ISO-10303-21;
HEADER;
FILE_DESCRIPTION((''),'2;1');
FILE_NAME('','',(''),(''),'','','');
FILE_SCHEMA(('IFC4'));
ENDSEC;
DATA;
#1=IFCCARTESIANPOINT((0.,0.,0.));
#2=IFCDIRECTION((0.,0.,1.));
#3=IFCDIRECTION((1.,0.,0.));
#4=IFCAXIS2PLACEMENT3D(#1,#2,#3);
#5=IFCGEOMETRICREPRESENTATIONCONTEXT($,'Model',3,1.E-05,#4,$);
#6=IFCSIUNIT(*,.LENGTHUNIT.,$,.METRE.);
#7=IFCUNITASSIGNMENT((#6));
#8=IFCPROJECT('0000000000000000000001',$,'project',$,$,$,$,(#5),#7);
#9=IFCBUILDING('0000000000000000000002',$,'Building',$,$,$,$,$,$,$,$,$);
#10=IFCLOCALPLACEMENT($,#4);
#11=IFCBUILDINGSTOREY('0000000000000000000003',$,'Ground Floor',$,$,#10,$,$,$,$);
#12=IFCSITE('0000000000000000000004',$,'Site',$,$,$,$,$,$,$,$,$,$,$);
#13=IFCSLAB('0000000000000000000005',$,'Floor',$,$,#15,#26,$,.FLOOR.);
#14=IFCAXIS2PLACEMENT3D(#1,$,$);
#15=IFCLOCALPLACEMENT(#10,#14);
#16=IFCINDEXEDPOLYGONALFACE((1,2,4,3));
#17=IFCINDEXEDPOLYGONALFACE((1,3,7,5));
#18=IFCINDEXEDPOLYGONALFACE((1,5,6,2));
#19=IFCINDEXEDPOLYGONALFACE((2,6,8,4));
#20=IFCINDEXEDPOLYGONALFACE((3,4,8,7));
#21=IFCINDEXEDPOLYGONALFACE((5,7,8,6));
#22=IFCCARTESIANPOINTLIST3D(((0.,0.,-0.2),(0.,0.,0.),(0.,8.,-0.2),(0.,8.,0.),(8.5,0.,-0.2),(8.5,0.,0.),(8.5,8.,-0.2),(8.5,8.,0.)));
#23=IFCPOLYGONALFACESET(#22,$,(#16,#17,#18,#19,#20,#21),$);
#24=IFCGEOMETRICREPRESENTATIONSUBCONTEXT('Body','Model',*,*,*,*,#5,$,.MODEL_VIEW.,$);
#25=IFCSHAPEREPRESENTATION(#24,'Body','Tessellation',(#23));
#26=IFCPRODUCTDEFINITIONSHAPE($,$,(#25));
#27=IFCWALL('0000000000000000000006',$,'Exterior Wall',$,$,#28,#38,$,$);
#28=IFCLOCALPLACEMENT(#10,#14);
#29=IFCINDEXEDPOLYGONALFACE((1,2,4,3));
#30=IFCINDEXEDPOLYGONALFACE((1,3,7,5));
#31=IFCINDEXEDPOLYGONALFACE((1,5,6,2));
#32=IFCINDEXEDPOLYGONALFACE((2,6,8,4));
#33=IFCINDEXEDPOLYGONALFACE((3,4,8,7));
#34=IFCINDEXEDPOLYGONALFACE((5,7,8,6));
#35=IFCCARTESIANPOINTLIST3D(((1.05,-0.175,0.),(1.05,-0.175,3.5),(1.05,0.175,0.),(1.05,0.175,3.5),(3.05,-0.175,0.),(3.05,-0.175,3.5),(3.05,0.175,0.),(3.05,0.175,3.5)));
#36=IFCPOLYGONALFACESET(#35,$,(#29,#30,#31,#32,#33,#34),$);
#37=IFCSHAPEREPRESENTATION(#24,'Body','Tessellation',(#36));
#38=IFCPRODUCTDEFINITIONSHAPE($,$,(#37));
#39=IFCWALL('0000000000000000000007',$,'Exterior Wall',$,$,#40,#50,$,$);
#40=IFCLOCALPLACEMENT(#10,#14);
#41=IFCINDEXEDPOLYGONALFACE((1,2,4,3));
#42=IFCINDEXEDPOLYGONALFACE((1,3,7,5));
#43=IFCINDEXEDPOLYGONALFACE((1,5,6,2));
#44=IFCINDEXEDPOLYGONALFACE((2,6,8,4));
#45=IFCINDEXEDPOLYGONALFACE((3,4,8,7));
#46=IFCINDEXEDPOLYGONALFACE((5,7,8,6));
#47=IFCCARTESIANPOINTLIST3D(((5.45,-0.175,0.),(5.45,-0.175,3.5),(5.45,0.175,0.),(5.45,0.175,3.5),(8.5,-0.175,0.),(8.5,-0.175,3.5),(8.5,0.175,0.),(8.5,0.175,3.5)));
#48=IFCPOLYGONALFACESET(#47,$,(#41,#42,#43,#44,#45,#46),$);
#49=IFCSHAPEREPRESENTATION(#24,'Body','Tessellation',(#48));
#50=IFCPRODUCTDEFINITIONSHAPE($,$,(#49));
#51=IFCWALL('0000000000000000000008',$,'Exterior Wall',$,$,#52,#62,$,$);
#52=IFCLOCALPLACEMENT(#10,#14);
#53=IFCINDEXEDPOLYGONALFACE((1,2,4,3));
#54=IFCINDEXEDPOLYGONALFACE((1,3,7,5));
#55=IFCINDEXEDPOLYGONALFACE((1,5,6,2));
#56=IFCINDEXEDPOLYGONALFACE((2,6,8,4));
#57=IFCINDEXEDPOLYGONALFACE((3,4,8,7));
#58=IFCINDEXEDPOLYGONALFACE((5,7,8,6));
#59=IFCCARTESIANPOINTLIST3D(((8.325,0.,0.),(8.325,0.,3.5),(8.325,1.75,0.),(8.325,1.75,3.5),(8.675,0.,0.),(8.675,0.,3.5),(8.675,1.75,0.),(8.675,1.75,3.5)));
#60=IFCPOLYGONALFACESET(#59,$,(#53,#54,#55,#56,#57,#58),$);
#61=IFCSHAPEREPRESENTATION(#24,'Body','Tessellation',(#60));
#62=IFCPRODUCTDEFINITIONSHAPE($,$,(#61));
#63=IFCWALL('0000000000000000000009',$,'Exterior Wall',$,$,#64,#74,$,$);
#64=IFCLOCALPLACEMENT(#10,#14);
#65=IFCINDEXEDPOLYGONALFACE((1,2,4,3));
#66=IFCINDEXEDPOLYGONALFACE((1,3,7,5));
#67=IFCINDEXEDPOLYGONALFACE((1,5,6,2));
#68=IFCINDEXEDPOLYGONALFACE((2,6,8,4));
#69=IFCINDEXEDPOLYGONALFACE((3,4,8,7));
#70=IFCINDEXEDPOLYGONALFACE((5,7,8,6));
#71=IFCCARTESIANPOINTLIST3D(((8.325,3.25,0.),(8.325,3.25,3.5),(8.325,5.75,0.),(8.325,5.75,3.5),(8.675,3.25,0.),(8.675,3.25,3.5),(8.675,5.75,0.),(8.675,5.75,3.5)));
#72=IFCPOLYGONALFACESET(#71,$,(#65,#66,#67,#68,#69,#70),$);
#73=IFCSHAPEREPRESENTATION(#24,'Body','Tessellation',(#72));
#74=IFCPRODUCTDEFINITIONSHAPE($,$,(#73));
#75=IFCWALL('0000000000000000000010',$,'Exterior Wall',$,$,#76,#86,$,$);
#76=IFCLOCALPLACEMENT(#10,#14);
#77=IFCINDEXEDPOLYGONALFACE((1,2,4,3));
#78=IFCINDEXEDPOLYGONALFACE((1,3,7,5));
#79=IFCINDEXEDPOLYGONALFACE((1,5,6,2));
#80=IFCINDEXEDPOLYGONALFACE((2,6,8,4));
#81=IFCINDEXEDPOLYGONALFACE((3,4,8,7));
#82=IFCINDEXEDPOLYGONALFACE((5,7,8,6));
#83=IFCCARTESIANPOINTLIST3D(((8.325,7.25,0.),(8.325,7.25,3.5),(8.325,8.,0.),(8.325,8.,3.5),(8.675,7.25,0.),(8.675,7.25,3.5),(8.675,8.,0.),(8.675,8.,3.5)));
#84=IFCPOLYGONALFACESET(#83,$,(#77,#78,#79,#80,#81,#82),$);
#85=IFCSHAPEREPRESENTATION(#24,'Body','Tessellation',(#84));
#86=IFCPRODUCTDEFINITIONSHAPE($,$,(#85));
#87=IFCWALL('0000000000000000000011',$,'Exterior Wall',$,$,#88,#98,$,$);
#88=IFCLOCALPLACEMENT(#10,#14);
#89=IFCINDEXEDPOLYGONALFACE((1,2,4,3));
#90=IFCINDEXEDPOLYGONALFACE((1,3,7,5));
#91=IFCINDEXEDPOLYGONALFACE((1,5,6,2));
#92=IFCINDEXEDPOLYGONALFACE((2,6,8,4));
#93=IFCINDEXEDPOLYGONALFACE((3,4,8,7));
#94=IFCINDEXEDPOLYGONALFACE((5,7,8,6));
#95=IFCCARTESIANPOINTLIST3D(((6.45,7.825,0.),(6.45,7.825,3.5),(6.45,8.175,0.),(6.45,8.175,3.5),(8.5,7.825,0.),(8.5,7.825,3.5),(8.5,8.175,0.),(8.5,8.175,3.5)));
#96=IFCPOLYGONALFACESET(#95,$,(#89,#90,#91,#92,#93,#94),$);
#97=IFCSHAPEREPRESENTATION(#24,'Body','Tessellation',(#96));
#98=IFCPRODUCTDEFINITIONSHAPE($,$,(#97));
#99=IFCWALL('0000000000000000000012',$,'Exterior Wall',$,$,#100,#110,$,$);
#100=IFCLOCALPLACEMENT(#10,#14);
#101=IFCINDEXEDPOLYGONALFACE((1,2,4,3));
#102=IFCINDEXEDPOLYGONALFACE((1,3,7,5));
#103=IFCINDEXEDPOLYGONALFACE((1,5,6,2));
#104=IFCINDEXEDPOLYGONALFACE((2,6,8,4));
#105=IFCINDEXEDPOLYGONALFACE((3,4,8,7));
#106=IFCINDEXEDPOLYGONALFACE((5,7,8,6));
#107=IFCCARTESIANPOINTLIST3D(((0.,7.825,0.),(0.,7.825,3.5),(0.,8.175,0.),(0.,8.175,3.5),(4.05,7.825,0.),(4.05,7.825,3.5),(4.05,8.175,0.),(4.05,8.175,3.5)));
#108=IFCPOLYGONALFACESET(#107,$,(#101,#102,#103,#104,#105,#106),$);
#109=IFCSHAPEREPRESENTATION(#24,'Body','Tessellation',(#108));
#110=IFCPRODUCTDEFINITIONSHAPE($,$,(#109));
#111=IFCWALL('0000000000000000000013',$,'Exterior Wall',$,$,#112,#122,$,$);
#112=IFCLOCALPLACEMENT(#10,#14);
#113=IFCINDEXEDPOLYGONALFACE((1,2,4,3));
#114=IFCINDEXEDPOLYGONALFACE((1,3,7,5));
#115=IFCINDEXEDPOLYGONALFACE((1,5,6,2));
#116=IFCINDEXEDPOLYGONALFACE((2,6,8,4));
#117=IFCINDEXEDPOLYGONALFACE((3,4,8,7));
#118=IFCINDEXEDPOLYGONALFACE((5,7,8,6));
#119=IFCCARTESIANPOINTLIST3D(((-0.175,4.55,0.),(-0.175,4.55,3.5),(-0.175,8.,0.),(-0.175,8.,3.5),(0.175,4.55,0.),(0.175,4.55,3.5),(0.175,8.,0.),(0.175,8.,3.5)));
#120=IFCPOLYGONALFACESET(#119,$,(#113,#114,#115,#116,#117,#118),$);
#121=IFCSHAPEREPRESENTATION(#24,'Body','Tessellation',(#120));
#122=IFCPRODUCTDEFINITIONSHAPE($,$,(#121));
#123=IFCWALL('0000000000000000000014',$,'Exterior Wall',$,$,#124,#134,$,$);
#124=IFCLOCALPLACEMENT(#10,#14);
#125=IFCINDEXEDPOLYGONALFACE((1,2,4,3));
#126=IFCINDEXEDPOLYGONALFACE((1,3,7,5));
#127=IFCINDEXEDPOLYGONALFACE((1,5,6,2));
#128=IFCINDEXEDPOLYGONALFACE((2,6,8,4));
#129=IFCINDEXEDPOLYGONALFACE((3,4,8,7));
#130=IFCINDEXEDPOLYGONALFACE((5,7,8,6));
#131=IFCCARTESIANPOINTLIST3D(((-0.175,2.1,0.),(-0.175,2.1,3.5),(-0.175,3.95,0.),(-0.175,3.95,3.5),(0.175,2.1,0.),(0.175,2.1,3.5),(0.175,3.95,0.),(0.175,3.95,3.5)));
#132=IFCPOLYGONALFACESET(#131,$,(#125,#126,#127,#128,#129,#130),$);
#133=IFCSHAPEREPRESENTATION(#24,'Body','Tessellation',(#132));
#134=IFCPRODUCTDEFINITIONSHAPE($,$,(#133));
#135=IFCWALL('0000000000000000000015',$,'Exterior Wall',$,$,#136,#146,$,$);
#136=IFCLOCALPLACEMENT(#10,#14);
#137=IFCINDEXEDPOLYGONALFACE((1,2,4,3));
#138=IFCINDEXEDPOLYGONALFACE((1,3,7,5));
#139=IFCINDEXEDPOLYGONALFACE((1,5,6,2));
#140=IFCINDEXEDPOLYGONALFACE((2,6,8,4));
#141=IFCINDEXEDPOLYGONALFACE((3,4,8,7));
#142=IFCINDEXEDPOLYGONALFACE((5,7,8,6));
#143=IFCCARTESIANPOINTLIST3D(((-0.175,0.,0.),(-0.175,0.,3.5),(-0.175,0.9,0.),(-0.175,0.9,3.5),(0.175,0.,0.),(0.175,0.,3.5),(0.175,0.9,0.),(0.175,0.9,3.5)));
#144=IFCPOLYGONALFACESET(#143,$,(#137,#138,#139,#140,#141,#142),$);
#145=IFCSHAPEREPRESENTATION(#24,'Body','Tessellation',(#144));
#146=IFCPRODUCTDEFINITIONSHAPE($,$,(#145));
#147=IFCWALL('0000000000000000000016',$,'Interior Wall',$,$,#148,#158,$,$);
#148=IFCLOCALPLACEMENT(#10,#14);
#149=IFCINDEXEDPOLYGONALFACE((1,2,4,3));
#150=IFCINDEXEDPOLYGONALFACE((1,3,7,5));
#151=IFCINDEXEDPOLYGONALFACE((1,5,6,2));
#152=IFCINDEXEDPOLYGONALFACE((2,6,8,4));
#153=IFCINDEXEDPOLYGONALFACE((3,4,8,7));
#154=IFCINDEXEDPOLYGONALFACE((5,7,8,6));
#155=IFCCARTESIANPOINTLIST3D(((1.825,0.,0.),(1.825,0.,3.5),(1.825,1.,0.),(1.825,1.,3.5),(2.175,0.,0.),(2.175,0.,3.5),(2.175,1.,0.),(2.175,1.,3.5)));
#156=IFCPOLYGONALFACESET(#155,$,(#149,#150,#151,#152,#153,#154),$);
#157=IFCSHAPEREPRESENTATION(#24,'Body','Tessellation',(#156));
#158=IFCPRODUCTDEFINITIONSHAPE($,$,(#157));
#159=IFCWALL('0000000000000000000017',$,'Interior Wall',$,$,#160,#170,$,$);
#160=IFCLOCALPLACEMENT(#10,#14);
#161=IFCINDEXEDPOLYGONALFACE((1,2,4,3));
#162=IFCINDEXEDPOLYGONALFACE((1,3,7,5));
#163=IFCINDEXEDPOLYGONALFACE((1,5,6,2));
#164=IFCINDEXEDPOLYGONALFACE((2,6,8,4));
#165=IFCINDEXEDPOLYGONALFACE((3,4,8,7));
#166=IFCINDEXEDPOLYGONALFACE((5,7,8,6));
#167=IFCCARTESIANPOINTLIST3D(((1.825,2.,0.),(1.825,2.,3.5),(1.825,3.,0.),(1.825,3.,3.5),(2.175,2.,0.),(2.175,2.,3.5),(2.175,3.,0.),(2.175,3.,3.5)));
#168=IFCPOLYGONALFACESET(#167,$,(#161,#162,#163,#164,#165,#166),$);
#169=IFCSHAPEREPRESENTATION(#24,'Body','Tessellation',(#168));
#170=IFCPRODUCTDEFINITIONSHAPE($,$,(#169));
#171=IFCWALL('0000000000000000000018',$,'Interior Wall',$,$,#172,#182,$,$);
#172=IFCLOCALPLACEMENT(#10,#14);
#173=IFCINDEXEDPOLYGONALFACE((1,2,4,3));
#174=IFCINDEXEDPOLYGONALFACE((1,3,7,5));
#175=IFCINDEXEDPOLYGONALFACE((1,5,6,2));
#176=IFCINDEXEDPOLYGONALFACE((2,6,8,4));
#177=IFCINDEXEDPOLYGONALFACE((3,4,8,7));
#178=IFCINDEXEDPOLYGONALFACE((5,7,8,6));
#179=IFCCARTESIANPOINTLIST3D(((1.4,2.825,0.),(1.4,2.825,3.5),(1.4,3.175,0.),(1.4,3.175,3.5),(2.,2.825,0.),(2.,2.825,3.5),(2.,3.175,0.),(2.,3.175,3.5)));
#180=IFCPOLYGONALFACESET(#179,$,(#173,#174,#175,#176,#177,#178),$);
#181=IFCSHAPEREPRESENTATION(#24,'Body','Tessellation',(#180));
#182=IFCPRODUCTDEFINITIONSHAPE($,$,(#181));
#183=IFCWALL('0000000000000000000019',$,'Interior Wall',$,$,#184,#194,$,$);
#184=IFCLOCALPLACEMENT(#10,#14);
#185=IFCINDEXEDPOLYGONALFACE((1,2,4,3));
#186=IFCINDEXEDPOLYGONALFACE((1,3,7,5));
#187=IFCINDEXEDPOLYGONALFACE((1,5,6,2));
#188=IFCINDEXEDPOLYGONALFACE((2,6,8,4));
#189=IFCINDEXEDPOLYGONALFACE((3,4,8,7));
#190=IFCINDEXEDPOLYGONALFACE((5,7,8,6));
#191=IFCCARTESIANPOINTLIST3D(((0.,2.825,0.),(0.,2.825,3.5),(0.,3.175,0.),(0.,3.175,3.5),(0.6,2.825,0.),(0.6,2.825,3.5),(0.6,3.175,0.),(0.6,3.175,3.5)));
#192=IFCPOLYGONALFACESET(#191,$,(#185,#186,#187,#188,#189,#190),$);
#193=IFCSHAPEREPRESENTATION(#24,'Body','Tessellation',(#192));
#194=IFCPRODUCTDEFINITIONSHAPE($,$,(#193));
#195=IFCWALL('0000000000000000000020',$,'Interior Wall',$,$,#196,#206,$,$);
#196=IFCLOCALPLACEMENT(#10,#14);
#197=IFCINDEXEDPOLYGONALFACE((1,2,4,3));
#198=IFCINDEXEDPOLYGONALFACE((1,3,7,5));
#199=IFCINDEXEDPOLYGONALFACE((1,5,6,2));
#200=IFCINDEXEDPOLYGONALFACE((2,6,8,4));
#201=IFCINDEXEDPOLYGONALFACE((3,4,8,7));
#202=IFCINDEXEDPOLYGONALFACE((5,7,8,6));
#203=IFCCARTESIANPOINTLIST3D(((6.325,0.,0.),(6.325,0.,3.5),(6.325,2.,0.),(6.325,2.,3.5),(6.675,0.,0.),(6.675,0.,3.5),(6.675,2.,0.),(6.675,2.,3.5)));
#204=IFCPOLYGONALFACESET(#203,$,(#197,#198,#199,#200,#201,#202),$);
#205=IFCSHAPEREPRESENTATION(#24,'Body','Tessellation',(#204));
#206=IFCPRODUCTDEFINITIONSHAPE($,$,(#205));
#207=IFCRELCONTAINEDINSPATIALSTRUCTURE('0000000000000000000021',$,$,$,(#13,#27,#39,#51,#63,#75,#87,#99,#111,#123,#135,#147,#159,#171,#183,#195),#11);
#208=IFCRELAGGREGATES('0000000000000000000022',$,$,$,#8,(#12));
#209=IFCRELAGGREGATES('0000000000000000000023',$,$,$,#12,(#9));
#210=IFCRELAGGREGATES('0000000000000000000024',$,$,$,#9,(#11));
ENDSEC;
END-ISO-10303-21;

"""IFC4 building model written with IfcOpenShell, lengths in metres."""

from ifc_helpers import new_model, si_unit, frame, origin_with_axes, place, context, subcontext, project, spatial, indexed_curve, outline, extrude, element, save


model = new_model("IFC4")

# Units and contexts
model_context = context("Model", 3, precision=1e-05, world=origin_with_axes())
body_context = subcontext(model_context, "Body", "Model", "MODEL_VIEW")
ifc_project = project(units=[si_unit("LENGTHUNIT", "METRE")], contexts=[model_context])

# Site, building, storey
site = spatial("IfcSite", under=ifc_project, Name="Site")
building = spatial("IfcBuilding", under=site, Name="Building")
storey_placement = place(None, origin_with_axes())
storey = spatial("IfcBuildingStorey", under=building, at=storey_placement, Name="Ground Floor")

# Slab
slab_placement = place(storey_placement, frame((0.0, 0.0, -0.2), z_axis=(0.0, 0.0, 1.0), x_axis=(1.0, 0.0, 0.0)))
element("IfcSlab", 1, at=slab_placement, inside=storey, Name="Floor", PredefinedType="FLOOR", context=body_context, shape_type="SweptSolid", body=[
    extrude(outline(indexed_curve([(0.0, 0.0), (8.5, 0.0), (8.5, 8.0), (0.0, 8.0)])), None, (0.0, 0.0, 1.0), 0.2),
])

# Walls
wall_1_placement = place(storey_placement, frame((1.05, 0.0, 0.0), z_axis=(0.0, 0.0, 1.0), x_axis=(1.0, 0.0, 0.0)))
element("IfcWall", 2, at=wall_1_placement, inside=storey, Name="Exterior Wall", context=body_context, shape_type="SweptSolid", body=[
    extrude(outline(indexed_curve([(0.0, 0.0), (0.0, 0.35), (2.0, 0.35), (2.0, 0.0), (0.0, 0.0)], self_intersect=False)), frame((0.0, -0.175, 0.0), z_axis=(0.0, 0.0, 1.0), x_axis=(1.0, 0.0, 0.0)), (0.0, 0.0, 1.0), 3.5),
])
wall_2_placement = place(storey_placement, frame((5.45, 0.0, 0.0), z_axis=(0.0, 0.0, 1.0), x_axis=(1.0, 0.0, 0.0)))
element("IfcWall", 3, at=wall_2_placement, inside=storey, Name="Exterior Wall", context=body_context, shape_type="SweptSolid", body=[
    extrude(outline(indexed_curve([(0.0, 0.0), (0.0, 0.35), (3.05, 0.35), (3.05, 0.0), (0.0, 0.0)], self_intersect=False)), frame((0.0, -0.175, 0.0), z_axis=(0.0, 0.0, 1.0), x_axis=(1.0, 0.0, 0.0)), (0.0, 0.0, 1.0), 3.5),
])
wall_3_placement = place(storey_placement, frame((8.5, 0.0, 0.0), z_axis=(0.0, 0.0, 1.0), x_axis=(0.0, 1.0, 0.0)))
element("IfcWall", 4, at=wall_3_placement, inside=storey, Name="Exterior Wall", context=body_context, shape_type="SweptSolid", body=[
    extrude(outline(indexed_curve([(0.0, 0.0), (0.0, 0.35), (1.75, 0.35), (1.75, 0.0), (0.0, 0.0)], self_intersect=False)), frame((0.0, -0.175, 0.0), z_axis=(0.0, 0.0, 1.0), x_axis=(1.0, 0.0, 0.0)), (0.0, 0.0, 1.0), 3.5),
])
wall_4_placement = place(storey_placement, frame((8.5, 3.25, 0.0), z_axis=(0.0, 0.0, 1.0), x_axis=(0.0, 1.0, 0.0)))
element("IfcWall", 5, at=wall_4_placement, inside=storey, Name="Exterior Wall", context=body_context, shape_type="SweptSolid", body=[
    extrude(outline(indexed_curve([(0.0, 0.0), (0.0, 0.35), (2.5, 0.35), (2.5, 0.0), (0.0, 0.0)], self_intersect=False)), frame((0.0, -0.175, 0.0), z_axis=(0.0, 0.0, 1.0), x_axis=(1.0, 0.0, 0.0)), (0.0, 0.0, 1.0), 3.5),
])
wall_5_placement = place(storey_placement, frame((8.5, 7.25, 0.0), z_axis=(0.0, 0.0, 1.0), x_axis=(0.0, 1.0, 0.0)))
element("IfcWall", 6, at=wall_5_placement, inside=storey, Name="Exterior Wall", context=body_context, shape_type="SweptSolid", body=[
    extrude(outline(indexed_curve([(0.0, 0.0), (0.0, 0.35), (0.75, 0.35), (0.75, 0.0), (0.0, 0.0)], self_intersect=False)), frame((0.0, -0.175, 0.0), z_axis=(0.0, 0.0, 1.0), x_axis=(1.0, 0.0, 0.0)), (0.0, 0.0, 1.0), 3.5),
])
wall_6_placement = place(storey_placement, frame((8.5, 8.0, 0.0), z_axis=(0.0, 0.0, 1.0), x_axis=(-1.0, 0.0, 0.0)))
element("IfcWall", 7, at=wall_6_placement, inside=storey, Name="Exterior Wall", context=body_context, shape_type="SweptSolid", body=[
    extrude(outline(indexed_curve([(0.0, 0.0), (0.0, 0.35), (2.05, 0.35), (2.05, 0.0), (0.0, 0.0)], self_intersect=False)), frame((0.0, -0.175, 0.0), z_axis=(0.0, 0.0, 1.0), x_axis=(1.0, 0.0, 0.0)), (0.0, 0.0, 1.0), 3.5),
])
wall_7_placement = place(storey_placement, frame((4.05, 8.0, 0.0), z_axis=(0.0, 0.0, 1.0), x_axis=(-1.0, 0.0, 0.0)))
element("IfcWall", 8, at=wall_7_placement, inside=storey, Name="Exterior Wall", context=body_context, shape_type="SweptSolid", body=[
    extrude(outline(indexed_curve([(0.0, 0.0), (0.0, 0.35), (4.05, 0.35), (4.05, 0.0), (0.0, 0.0)], self_intersect=False)), frame((0.0, -0.175, 0.0), z_axis=(0.0, 0.0, 1.0), x_axis=(1.0, 0.0, 0.0)), (0.0, 0.0, 1.0), 3.5),
])
wall_8_placement = place(storey_placement, frame((0.0, 8.0, 0.0), z_axis=(0.0, 0.0, 1.0), x_axis=(0.0, -1.0, 0.0)))
element("IfcWall", 9, at=wall_8_placement, inside=storey, Name="Exterior Wall", context=body_context, shape_type="SweptSolid", body=[
    extrude(outline(indexed_curve([(0.0, 0.0), (0.0, 0.35), (3.45, 0.35), (3.45, 0.0), (0.0, 0.0)], self_intersect=False)), frame((0.0, -0.175, 0.0), z_axis=(0.0, 0.0, 1.0), x_axis=(1.0, 0.0, 0.0)), (0.0, 0.0, 1.0), 3.5),
])
wall_9_placement = place(storey_placement, frame((0.0, 3.95, 0.0), z_axis=(0.0, 0.0, 1.0), x_axis=(0.0, -1.0, 0.0)))
element("IfcWall", 10, at=wall_9_placement, inside=storey, Name="Exterior Wall", context=body_context, shape_type="SweptSolid", body=[
    extrude(outline(indexed_curve([(0.0, 0.0), (0.0, 0.35), (1.85, 0.35), (1.85, 0.0), (0.0, 0.0)], self_intersect=False)), frame((0.0, -0.175, 0.0), z_axis=(0.0, 0.0, 1.0), x_axis=(1.0, 0.0, 0.0)), (0.0, 0.0, 1.0), 3.5),
])
wall_10_placement = place(storey_placement, frame((0.0, 0.9, 0.0), z_axis=(0.0, 0.0, 1.0), x_axis=(0.0, -1.0, 0.0)))
element("IfcWall", 11, at=wall_10_placement, inside=storey, Name="Exterior Wall", context=body_context, shape_type="SweptSolid", body=[
    extrude(outline(indexed_curve([(0.0, 0.0), (0.0, 0.35), (0.9, 0.35), (0.9, 0.0), (0.0, 0.0)], self_intersect=False)), frame((0.0, -0.175, 0.0), z_axis=(0.0, 0.0, 1.0), x_axis=(1.0, 0.0, 0.0)), (0.0, 0.0, 1.0), 3.5),
])
for number, where, z_axis, x_axis, name in (
    (12, (2.0, 0.0, 0.0), (0.0, 0.0, 1.0), (0.0, 1.0, 0.0), "Interior Wall"),
    (13, (2.0, 2.0, 0.0), (0.0, 0.0, 1.0), (0.0, 1.0, 0.0), "Interior Wall"),
):
    element("IfcWall", number, at=place(storey_placement, frame(where, z_axis=z_axis, x_axis=x_axis)), inside=storey, Name=name, context=body_context, shape_type="SweptSolid", body=[
        extrude(outline(indexed_curve([(0.0, 0.0), (0.0, 0.35), (1.0, 0.35), (1.0, 0.0), (0.0, 0.0)], self_intersect=False)), frame((0.0, -0.175, 0.0), z_axis=(0.0, 0.0, 1.0), x_axis=(1.0, 0.0, 0.0)), (0.0, 0.0, 1.0), 3.5),
    ])
for number, where, z_axis, x_axis, name in (
    (14, (2.0, 3.0, 0.0), (0.0, 0.0, 1.0), (-1.0, 0.0, 0.0), "Interior Wall"),
    (15, (0.6, 3.0, 0.0), (0.0, 0.0, 1.0), (-1.0, 0.0, 0.0), "Interior Wall"),
):
    element("IfcWall", number, at=place(storey_placement, frame(where, z_axis=z_axis, x_axis=x_axis)), inside=storey, Name=name, context=body_context, shape_type="SweptSolid", body=[
        extrude(outline(indexed_curve([(0.0, 0.0), (0.0, 0.35), (0.6, 0.35), (0.6, 0.0), (0.0, 0.0)], self_intersect=False)), frame((0.0, -0.175, 0.0), z_axis=(0.0, 0.0, 1.0), x_axis=(1.0, 0.0, 0.0)), (0.0, 0.0, 1.0), 3.5),
    ])
for number, where, z_axis, x_axis, name in (
    (16, (6.5, 0.0, 0.0), (0.0, 0.0, 1.0), (0.0, 1.0, 0.0), "Interior Wall"),
):
    element("IfcWall", number, at=place(storey_placement, frame(where, z_axis=z_axis, x_axis=x_axis)), inside=storey, Name=name, context=body_context, shape_type="SweptSolid", body=[
        extrude(outline(indexed_curve([(0.0, 0.0), (0.0, 0.35), (2.0, 0.35), (2.0, 0.0), (0.0, 0.0)], self_intersect=False)), frame((0.0, -0.175, 0.0), z_axis=(0.0, 0.0, 1.0), x_axis=(1.0, 0.0, 0.0)), (0.0, 0.0, 1.0), 3.5),
    ])

save(model, "model.ifc")
